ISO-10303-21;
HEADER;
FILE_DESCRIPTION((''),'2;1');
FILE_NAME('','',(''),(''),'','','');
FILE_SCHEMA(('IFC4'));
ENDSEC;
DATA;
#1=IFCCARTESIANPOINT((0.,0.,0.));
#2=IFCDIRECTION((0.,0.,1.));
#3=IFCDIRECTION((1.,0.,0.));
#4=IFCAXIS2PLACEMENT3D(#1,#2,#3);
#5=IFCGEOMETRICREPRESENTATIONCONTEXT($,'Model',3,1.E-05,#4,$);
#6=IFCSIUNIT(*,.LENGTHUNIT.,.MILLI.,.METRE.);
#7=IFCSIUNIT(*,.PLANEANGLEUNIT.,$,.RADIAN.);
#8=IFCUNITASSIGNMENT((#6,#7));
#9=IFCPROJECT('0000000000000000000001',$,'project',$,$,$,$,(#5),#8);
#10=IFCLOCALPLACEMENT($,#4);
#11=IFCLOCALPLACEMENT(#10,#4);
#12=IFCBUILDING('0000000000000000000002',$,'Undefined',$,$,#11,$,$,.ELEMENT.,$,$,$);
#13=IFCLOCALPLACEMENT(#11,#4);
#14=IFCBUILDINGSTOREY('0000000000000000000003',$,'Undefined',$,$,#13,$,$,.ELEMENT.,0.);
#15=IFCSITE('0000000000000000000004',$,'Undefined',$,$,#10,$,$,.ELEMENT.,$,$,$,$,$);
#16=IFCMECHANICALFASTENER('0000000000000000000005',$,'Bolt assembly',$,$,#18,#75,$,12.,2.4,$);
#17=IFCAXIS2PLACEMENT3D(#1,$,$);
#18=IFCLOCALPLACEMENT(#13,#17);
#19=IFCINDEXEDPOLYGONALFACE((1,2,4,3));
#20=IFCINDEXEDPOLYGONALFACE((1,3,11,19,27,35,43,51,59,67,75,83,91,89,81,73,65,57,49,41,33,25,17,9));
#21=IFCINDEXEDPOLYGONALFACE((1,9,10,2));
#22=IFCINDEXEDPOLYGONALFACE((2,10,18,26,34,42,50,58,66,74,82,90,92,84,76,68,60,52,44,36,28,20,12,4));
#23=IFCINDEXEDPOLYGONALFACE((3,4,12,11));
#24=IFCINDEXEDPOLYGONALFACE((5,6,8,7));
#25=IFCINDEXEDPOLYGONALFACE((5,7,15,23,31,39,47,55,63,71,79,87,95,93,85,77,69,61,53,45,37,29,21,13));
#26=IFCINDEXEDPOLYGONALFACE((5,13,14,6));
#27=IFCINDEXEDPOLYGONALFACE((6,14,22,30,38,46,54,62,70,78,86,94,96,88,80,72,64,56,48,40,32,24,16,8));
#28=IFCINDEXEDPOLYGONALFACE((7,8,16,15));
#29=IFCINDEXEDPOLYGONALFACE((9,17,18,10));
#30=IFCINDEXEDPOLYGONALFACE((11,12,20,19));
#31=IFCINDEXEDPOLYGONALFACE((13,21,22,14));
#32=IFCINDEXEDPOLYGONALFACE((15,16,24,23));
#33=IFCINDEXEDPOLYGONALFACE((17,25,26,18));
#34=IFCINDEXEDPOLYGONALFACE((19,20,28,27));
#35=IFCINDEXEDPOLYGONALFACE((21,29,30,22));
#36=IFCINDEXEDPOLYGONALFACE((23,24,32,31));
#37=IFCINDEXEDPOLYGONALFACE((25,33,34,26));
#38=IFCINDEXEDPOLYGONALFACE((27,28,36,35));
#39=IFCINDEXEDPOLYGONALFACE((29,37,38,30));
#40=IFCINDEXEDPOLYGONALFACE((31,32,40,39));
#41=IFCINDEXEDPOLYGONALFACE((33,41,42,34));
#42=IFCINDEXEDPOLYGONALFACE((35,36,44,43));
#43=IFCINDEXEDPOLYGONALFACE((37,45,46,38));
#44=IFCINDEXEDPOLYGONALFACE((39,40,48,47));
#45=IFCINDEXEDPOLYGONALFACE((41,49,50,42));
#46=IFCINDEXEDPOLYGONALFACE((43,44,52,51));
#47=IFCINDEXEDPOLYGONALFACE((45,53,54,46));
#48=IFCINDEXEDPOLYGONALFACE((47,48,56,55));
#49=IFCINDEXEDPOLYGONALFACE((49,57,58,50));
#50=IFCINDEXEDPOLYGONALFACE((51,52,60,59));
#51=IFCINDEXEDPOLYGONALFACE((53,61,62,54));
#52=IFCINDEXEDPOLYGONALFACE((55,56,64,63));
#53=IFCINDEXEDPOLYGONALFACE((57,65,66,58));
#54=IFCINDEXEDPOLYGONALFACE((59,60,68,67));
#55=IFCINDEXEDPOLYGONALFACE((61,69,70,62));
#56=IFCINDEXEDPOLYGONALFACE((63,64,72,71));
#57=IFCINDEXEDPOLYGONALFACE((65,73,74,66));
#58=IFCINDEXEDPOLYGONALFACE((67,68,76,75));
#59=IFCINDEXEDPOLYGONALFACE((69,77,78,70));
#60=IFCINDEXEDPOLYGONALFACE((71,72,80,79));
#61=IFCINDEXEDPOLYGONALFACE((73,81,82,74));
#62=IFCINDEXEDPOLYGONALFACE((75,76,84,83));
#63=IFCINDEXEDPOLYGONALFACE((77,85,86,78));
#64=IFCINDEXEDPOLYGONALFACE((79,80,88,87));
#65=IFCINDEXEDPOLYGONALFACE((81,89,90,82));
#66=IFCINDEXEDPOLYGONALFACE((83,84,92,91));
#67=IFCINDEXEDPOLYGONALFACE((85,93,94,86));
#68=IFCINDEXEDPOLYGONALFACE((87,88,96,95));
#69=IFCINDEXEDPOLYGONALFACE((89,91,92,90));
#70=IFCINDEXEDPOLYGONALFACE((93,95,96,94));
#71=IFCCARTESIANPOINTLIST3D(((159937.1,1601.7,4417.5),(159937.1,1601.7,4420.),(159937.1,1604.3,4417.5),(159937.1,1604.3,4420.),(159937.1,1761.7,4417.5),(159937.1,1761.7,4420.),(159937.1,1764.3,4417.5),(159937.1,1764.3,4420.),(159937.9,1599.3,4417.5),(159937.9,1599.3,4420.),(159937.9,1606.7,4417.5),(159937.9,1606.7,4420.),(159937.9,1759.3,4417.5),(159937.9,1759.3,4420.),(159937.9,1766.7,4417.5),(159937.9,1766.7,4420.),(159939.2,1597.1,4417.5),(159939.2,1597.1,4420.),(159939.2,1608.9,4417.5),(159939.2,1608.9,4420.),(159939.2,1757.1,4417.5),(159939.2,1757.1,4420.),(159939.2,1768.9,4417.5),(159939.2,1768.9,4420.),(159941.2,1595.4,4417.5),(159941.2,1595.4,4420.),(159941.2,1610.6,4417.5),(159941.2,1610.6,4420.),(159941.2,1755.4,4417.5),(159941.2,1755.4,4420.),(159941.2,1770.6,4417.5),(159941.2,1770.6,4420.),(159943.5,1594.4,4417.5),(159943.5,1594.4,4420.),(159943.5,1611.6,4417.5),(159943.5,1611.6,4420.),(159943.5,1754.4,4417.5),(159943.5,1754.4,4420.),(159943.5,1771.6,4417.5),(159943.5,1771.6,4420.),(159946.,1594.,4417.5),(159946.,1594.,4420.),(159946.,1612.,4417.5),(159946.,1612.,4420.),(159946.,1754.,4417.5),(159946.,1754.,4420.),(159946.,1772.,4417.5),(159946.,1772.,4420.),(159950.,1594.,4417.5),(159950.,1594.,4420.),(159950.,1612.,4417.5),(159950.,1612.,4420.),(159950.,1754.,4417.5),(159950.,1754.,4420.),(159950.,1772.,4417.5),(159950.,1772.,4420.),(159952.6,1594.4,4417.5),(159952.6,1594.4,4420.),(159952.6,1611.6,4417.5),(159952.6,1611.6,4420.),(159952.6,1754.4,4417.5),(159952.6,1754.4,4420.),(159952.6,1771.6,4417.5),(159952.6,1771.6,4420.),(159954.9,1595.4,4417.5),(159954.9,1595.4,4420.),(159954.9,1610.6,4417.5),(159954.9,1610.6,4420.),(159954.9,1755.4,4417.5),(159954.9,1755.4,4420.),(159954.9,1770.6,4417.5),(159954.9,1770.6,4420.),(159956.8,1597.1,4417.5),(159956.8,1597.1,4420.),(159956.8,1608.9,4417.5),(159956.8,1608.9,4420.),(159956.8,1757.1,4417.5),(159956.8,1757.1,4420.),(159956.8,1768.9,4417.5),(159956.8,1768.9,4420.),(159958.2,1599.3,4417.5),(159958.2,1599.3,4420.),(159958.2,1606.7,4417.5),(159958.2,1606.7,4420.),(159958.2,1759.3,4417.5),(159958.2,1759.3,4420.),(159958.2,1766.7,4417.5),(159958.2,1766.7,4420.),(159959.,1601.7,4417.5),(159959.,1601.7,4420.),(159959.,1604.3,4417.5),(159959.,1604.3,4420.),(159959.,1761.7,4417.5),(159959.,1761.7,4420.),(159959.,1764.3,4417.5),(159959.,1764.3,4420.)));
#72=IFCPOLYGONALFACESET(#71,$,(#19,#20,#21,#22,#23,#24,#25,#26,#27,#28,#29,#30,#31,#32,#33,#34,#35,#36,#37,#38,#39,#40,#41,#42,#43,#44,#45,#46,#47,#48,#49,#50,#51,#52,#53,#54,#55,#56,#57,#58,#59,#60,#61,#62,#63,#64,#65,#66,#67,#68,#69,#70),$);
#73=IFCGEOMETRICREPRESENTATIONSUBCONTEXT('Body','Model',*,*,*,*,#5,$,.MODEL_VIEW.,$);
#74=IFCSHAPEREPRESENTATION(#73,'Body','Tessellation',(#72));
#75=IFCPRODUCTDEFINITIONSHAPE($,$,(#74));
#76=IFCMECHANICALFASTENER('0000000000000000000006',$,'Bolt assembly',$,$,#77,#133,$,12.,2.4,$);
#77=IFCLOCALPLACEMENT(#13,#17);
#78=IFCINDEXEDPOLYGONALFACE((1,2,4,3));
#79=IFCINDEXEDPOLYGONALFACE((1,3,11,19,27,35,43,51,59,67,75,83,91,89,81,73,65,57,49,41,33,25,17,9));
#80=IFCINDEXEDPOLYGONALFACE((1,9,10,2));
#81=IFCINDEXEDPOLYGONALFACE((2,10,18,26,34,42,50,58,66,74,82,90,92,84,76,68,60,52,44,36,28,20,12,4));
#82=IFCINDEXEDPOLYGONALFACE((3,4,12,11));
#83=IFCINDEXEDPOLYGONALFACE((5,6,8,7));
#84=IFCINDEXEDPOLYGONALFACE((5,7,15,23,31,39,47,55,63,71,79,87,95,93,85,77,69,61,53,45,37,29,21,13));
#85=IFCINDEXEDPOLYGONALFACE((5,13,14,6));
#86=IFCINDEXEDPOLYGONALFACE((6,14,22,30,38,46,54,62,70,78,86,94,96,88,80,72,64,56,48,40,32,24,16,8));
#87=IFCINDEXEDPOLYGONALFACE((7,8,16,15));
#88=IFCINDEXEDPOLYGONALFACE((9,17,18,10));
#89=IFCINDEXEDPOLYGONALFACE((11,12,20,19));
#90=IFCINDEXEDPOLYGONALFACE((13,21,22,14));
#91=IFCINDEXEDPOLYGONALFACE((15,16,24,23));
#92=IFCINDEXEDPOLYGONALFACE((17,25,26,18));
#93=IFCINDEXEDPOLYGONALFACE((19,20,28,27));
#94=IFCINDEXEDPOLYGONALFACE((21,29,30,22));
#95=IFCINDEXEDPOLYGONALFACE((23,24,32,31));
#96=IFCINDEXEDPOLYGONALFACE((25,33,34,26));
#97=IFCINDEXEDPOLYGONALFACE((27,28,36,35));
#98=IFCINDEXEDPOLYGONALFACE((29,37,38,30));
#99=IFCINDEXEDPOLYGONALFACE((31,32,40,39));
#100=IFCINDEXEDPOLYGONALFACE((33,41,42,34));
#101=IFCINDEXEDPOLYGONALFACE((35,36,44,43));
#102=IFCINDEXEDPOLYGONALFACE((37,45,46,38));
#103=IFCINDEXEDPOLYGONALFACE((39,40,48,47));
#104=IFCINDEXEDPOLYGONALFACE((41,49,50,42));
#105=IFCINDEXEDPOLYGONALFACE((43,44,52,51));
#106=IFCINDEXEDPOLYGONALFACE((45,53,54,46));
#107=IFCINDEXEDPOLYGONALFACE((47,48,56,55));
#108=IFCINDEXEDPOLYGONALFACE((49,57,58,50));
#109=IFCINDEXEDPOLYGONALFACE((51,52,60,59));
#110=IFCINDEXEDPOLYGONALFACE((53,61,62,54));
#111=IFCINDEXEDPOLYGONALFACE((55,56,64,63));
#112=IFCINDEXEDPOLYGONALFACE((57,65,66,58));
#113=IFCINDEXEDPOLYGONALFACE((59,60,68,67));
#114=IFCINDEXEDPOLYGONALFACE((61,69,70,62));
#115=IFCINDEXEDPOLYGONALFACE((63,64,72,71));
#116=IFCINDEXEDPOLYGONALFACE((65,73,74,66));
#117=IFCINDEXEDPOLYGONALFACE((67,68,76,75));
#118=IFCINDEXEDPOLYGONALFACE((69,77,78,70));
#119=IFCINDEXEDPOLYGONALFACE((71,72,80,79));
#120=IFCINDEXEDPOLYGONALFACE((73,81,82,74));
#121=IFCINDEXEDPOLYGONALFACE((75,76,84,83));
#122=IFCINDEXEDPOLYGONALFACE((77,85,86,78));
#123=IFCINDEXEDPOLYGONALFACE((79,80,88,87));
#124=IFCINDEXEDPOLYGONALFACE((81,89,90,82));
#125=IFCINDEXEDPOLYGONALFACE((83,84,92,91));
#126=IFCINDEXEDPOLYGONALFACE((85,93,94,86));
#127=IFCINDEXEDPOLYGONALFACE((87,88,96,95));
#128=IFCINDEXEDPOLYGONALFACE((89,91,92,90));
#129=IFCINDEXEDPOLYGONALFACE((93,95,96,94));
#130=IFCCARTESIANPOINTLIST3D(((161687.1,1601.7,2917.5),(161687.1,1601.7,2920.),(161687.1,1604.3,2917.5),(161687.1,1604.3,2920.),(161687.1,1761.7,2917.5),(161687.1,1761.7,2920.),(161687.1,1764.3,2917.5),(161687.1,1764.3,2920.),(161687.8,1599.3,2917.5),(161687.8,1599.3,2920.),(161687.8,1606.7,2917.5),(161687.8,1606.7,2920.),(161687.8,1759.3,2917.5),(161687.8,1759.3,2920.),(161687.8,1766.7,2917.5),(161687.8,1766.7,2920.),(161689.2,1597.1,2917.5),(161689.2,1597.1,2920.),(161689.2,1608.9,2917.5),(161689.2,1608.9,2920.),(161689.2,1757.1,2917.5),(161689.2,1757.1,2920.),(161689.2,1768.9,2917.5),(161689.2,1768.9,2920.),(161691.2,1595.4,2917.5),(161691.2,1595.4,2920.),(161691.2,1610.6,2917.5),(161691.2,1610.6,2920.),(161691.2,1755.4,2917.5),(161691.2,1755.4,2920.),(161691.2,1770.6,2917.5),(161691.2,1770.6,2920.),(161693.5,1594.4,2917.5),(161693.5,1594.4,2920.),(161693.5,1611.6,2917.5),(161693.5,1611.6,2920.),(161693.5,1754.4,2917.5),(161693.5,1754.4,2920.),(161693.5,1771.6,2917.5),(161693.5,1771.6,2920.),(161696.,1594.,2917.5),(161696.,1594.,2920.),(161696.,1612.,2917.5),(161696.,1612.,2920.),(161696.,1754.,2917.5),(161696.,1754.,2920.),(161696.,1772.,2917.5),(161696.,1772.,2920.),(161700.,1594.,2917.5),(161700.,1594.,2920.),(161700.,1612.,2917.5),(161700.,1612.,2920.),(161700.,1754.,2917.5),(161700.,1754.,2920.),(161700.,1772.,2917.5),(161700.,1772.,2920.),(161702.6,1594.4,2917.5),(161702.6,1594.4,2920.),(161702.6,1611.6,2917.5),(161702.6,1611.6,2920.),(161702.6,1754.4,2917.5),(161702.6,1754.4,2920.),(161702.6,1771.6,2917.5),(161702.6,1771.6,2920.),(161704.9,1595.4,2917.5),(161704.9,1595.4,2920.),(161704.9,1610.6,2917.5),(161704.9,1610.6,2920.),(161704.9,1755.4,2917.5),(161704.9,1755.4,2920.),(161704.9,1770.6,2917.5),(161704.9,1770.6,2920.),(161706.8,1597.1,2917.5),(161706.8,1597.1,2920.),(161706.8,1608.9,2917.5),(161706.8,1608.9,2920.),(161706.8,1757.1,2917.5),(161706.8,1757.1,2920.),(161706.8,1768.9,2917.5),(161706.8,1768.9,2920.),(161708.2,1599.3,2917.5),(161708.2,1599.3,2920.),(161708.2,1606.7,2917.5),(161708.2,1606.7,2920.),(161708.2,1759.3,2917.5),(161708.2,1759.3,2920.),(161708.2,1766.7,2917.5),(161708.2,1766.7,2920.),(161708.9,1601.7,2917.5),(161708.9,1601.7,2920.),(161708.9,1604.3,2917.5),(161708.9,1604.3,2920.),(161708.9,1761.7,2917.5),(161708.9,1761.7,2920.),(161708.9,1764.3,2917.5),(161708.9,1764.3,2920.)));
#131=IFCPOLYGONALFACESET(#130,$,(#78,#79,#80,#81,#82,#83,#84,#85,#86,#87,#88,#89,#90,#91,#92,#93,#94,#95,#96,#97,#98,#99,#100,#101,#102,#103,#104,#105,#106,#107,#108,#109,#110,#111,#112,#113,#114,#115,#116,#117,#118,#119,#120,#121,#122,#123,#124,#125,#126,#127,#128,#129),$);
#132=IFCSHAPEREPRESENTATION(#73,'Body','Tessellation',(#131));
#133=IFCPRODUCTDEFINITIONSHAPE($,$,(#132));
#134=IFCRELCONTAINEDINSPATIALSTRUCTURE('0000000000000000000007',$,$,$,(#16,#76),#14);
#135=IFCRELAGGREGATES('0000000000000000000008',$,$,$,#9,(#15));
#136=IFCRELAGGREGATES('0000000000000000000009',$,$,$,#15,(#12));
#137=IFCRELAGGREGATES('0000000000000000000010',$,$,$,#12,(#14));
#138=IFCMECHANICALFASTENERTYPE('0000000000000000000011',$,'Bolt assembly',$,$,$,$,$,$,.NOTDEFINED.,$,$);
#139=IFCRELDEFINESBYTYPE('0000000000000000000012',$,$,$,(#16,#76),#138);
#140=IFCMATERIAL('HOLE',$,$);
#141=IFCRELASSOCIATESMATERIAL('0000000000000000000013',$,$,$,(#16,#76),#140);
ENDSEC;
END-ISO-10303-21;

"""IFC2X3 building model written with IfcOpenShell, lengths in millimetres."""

from ifc_helpers import new_model, si_unit, frame, frame_2d, origin_with_axes, place, context, subcontext, project, spatial, polyline, circle_curve, parameter, trimmed, segment, composite_curve, outline, extrude, source, transform, mapped, material, type_object, element, save


model = new_model("IFC2X3")

# Units and contexts
model_context = context("Model", 3, precision=1e-05, world=origin_with_axes())
body_context = subcontext(model_context, "Body", "Model", "MODEL_VIEW")
ifc_project = project(units=[si_unit("LENGTHUNIT", "METRE", prefix="MILLI"), si_unit("PLANEANGLEUNIT", "RADIAN")], contexts=[model_context])

# Site, building, storey
site_placement = place(None, origin_with_axes())
site = spatial("IfcSite", under=ifc_project, at=site_placement, Name="Undefined", CompositionType="ELEMENT")
building_placement = place(site_placement, origin_with_axes())
building = spatial("IfcBuilding", under=site, at=building_placement, Name="Undefined", CompositionType="ELEMENT")
storey_placement = place(building_placement, origin_with_axes())
storey = spatial("IfcBuildingStorey", under=building, at=storey_placement, Name="Undefined", CompositionType="ELEMENT", Elevation=0.0)

# Mechanical fasteners
ifc_material_1 = material(Name="HOLE")
mechanical_fastener_type = type_object("IfcMechanicalFastenerType", Name="Bolt assembly")
shared_shape_1 = source(origin_with_axes(), body_context, "Body", "SweptSolid", [
    extrude(outline(composite_curve([segment(polyline([(-2.0, 9.0), (2.0, 9.0)]), True, "CONTINUOUS"), segment(trimmed(circle_curve(frame_2d((2.0, 0.0), x_axis=(0.0, 1.0)), 9.0), [parameter(0.0)], [parameter(3.141593)], False, "PARAMETER"), True, "CONTINUOUS"), segment(polyline([(2.0, -9.0), (-2.0, -9.0)]), True, "CONTINUOUS"), segment(trimmed(circle_curve(frame_2d((-2.0, 0.0), x_axis=(0.0, -1.0)), 9.0), [parameter(0.0)], [parameter(3.141593)], False, "PARAMETER"), True, "DISCONTINUOUS")], self_intersect=False)), frame((0.0, -2.4, 0.0), z_axis=(0.0, 1.0, 0.0), x_axis=(1.0, 0.0, 0.0)), (0.0, 0.0, 1.0), 2.5),
])
mechanical_fastener_1_placement = place(storey_placement, frame((159948.0, 1683.0, 4417.6), z_axis=(0.0, -1.0, 0.0), x_axis=(-1.0, 0.0, 0.0)))
element("IfcMechanicalFastener", 1, at=mechanical_fastener_1_placement, inside=storey, type_object=mechanical_fastener_type, material=ifc_material_1, Name="Bolt assembly", NominalDiameter=12.0, NominalLength=2.4, context=body_context, shape_type="MappedRepresentation", body=[
    mapped(shared_shape_1, transform((0.0, 0.0, -80.0))),
    mapped(shared_shape_1, transform((0.0, 0.0, 80.0))),
])
shared_shape_2 = source(origin_with_axes(), body_context, "Body", "SweptSolid", [
    extrude(outline(composite_curve([segment(polyline([(-2.0, 9.0), (2.0, 9.0)]), True, "CONTINUOUS"), segment(trimmed(circle_curve(frame_2d((2.0, 0.0), x_axis=(0.0, 1.0)), 9.0), [parameter(0.0)], [parameter(3.141593)], False, "PARAMETER"), True, "CONTINUOUS"), segment(polyline([(2.0, -9.0), (-2.0, -9.0)]), True, "CONTINUOUS"), segment(trimmed(circle_curve(frame_2d((-2.0, 0.0), x_axis=(0.0, -1.0)), 9.0), [parameter(0.0)], [parameter(3.141593)], False, "PARAMETER"), True, "DISCONTINUOUS")], self_intersect=False)), frame((0.0, -2.4, 0.0), z_axis=(0.0, 1.0, 0.0), x_axis=(1.0, 0.0, 0.0)), (0.0, 0.0, 1.0), 2.5),
])
mechanical_fastener_2_placement = place(storey_placement, frame((161698.0, 1683.0, 2917.6), z_axis=(0.0, -1.0, 0.0), x_axis=(-1.0, 0.0, 0.0)))
element("IfcMechanicalFastener", 2, at=mechanical_fastener_2_placement, inside=storey, type_object=mechanical_fastener_type, material=ifc_material_1, Name="Bolt assembly", NominalDiameter=12.0, NominalLength=2.4, context=body_context, shape_type="MappedRepresentation", body=[
    mapped(shared_shape_2, transform((0.0, 0.0, -80.0))),
    mapped(shared_shape_2, transform((0.0, 0.0, 80.0))),
])

save(model, "model.ifc")
